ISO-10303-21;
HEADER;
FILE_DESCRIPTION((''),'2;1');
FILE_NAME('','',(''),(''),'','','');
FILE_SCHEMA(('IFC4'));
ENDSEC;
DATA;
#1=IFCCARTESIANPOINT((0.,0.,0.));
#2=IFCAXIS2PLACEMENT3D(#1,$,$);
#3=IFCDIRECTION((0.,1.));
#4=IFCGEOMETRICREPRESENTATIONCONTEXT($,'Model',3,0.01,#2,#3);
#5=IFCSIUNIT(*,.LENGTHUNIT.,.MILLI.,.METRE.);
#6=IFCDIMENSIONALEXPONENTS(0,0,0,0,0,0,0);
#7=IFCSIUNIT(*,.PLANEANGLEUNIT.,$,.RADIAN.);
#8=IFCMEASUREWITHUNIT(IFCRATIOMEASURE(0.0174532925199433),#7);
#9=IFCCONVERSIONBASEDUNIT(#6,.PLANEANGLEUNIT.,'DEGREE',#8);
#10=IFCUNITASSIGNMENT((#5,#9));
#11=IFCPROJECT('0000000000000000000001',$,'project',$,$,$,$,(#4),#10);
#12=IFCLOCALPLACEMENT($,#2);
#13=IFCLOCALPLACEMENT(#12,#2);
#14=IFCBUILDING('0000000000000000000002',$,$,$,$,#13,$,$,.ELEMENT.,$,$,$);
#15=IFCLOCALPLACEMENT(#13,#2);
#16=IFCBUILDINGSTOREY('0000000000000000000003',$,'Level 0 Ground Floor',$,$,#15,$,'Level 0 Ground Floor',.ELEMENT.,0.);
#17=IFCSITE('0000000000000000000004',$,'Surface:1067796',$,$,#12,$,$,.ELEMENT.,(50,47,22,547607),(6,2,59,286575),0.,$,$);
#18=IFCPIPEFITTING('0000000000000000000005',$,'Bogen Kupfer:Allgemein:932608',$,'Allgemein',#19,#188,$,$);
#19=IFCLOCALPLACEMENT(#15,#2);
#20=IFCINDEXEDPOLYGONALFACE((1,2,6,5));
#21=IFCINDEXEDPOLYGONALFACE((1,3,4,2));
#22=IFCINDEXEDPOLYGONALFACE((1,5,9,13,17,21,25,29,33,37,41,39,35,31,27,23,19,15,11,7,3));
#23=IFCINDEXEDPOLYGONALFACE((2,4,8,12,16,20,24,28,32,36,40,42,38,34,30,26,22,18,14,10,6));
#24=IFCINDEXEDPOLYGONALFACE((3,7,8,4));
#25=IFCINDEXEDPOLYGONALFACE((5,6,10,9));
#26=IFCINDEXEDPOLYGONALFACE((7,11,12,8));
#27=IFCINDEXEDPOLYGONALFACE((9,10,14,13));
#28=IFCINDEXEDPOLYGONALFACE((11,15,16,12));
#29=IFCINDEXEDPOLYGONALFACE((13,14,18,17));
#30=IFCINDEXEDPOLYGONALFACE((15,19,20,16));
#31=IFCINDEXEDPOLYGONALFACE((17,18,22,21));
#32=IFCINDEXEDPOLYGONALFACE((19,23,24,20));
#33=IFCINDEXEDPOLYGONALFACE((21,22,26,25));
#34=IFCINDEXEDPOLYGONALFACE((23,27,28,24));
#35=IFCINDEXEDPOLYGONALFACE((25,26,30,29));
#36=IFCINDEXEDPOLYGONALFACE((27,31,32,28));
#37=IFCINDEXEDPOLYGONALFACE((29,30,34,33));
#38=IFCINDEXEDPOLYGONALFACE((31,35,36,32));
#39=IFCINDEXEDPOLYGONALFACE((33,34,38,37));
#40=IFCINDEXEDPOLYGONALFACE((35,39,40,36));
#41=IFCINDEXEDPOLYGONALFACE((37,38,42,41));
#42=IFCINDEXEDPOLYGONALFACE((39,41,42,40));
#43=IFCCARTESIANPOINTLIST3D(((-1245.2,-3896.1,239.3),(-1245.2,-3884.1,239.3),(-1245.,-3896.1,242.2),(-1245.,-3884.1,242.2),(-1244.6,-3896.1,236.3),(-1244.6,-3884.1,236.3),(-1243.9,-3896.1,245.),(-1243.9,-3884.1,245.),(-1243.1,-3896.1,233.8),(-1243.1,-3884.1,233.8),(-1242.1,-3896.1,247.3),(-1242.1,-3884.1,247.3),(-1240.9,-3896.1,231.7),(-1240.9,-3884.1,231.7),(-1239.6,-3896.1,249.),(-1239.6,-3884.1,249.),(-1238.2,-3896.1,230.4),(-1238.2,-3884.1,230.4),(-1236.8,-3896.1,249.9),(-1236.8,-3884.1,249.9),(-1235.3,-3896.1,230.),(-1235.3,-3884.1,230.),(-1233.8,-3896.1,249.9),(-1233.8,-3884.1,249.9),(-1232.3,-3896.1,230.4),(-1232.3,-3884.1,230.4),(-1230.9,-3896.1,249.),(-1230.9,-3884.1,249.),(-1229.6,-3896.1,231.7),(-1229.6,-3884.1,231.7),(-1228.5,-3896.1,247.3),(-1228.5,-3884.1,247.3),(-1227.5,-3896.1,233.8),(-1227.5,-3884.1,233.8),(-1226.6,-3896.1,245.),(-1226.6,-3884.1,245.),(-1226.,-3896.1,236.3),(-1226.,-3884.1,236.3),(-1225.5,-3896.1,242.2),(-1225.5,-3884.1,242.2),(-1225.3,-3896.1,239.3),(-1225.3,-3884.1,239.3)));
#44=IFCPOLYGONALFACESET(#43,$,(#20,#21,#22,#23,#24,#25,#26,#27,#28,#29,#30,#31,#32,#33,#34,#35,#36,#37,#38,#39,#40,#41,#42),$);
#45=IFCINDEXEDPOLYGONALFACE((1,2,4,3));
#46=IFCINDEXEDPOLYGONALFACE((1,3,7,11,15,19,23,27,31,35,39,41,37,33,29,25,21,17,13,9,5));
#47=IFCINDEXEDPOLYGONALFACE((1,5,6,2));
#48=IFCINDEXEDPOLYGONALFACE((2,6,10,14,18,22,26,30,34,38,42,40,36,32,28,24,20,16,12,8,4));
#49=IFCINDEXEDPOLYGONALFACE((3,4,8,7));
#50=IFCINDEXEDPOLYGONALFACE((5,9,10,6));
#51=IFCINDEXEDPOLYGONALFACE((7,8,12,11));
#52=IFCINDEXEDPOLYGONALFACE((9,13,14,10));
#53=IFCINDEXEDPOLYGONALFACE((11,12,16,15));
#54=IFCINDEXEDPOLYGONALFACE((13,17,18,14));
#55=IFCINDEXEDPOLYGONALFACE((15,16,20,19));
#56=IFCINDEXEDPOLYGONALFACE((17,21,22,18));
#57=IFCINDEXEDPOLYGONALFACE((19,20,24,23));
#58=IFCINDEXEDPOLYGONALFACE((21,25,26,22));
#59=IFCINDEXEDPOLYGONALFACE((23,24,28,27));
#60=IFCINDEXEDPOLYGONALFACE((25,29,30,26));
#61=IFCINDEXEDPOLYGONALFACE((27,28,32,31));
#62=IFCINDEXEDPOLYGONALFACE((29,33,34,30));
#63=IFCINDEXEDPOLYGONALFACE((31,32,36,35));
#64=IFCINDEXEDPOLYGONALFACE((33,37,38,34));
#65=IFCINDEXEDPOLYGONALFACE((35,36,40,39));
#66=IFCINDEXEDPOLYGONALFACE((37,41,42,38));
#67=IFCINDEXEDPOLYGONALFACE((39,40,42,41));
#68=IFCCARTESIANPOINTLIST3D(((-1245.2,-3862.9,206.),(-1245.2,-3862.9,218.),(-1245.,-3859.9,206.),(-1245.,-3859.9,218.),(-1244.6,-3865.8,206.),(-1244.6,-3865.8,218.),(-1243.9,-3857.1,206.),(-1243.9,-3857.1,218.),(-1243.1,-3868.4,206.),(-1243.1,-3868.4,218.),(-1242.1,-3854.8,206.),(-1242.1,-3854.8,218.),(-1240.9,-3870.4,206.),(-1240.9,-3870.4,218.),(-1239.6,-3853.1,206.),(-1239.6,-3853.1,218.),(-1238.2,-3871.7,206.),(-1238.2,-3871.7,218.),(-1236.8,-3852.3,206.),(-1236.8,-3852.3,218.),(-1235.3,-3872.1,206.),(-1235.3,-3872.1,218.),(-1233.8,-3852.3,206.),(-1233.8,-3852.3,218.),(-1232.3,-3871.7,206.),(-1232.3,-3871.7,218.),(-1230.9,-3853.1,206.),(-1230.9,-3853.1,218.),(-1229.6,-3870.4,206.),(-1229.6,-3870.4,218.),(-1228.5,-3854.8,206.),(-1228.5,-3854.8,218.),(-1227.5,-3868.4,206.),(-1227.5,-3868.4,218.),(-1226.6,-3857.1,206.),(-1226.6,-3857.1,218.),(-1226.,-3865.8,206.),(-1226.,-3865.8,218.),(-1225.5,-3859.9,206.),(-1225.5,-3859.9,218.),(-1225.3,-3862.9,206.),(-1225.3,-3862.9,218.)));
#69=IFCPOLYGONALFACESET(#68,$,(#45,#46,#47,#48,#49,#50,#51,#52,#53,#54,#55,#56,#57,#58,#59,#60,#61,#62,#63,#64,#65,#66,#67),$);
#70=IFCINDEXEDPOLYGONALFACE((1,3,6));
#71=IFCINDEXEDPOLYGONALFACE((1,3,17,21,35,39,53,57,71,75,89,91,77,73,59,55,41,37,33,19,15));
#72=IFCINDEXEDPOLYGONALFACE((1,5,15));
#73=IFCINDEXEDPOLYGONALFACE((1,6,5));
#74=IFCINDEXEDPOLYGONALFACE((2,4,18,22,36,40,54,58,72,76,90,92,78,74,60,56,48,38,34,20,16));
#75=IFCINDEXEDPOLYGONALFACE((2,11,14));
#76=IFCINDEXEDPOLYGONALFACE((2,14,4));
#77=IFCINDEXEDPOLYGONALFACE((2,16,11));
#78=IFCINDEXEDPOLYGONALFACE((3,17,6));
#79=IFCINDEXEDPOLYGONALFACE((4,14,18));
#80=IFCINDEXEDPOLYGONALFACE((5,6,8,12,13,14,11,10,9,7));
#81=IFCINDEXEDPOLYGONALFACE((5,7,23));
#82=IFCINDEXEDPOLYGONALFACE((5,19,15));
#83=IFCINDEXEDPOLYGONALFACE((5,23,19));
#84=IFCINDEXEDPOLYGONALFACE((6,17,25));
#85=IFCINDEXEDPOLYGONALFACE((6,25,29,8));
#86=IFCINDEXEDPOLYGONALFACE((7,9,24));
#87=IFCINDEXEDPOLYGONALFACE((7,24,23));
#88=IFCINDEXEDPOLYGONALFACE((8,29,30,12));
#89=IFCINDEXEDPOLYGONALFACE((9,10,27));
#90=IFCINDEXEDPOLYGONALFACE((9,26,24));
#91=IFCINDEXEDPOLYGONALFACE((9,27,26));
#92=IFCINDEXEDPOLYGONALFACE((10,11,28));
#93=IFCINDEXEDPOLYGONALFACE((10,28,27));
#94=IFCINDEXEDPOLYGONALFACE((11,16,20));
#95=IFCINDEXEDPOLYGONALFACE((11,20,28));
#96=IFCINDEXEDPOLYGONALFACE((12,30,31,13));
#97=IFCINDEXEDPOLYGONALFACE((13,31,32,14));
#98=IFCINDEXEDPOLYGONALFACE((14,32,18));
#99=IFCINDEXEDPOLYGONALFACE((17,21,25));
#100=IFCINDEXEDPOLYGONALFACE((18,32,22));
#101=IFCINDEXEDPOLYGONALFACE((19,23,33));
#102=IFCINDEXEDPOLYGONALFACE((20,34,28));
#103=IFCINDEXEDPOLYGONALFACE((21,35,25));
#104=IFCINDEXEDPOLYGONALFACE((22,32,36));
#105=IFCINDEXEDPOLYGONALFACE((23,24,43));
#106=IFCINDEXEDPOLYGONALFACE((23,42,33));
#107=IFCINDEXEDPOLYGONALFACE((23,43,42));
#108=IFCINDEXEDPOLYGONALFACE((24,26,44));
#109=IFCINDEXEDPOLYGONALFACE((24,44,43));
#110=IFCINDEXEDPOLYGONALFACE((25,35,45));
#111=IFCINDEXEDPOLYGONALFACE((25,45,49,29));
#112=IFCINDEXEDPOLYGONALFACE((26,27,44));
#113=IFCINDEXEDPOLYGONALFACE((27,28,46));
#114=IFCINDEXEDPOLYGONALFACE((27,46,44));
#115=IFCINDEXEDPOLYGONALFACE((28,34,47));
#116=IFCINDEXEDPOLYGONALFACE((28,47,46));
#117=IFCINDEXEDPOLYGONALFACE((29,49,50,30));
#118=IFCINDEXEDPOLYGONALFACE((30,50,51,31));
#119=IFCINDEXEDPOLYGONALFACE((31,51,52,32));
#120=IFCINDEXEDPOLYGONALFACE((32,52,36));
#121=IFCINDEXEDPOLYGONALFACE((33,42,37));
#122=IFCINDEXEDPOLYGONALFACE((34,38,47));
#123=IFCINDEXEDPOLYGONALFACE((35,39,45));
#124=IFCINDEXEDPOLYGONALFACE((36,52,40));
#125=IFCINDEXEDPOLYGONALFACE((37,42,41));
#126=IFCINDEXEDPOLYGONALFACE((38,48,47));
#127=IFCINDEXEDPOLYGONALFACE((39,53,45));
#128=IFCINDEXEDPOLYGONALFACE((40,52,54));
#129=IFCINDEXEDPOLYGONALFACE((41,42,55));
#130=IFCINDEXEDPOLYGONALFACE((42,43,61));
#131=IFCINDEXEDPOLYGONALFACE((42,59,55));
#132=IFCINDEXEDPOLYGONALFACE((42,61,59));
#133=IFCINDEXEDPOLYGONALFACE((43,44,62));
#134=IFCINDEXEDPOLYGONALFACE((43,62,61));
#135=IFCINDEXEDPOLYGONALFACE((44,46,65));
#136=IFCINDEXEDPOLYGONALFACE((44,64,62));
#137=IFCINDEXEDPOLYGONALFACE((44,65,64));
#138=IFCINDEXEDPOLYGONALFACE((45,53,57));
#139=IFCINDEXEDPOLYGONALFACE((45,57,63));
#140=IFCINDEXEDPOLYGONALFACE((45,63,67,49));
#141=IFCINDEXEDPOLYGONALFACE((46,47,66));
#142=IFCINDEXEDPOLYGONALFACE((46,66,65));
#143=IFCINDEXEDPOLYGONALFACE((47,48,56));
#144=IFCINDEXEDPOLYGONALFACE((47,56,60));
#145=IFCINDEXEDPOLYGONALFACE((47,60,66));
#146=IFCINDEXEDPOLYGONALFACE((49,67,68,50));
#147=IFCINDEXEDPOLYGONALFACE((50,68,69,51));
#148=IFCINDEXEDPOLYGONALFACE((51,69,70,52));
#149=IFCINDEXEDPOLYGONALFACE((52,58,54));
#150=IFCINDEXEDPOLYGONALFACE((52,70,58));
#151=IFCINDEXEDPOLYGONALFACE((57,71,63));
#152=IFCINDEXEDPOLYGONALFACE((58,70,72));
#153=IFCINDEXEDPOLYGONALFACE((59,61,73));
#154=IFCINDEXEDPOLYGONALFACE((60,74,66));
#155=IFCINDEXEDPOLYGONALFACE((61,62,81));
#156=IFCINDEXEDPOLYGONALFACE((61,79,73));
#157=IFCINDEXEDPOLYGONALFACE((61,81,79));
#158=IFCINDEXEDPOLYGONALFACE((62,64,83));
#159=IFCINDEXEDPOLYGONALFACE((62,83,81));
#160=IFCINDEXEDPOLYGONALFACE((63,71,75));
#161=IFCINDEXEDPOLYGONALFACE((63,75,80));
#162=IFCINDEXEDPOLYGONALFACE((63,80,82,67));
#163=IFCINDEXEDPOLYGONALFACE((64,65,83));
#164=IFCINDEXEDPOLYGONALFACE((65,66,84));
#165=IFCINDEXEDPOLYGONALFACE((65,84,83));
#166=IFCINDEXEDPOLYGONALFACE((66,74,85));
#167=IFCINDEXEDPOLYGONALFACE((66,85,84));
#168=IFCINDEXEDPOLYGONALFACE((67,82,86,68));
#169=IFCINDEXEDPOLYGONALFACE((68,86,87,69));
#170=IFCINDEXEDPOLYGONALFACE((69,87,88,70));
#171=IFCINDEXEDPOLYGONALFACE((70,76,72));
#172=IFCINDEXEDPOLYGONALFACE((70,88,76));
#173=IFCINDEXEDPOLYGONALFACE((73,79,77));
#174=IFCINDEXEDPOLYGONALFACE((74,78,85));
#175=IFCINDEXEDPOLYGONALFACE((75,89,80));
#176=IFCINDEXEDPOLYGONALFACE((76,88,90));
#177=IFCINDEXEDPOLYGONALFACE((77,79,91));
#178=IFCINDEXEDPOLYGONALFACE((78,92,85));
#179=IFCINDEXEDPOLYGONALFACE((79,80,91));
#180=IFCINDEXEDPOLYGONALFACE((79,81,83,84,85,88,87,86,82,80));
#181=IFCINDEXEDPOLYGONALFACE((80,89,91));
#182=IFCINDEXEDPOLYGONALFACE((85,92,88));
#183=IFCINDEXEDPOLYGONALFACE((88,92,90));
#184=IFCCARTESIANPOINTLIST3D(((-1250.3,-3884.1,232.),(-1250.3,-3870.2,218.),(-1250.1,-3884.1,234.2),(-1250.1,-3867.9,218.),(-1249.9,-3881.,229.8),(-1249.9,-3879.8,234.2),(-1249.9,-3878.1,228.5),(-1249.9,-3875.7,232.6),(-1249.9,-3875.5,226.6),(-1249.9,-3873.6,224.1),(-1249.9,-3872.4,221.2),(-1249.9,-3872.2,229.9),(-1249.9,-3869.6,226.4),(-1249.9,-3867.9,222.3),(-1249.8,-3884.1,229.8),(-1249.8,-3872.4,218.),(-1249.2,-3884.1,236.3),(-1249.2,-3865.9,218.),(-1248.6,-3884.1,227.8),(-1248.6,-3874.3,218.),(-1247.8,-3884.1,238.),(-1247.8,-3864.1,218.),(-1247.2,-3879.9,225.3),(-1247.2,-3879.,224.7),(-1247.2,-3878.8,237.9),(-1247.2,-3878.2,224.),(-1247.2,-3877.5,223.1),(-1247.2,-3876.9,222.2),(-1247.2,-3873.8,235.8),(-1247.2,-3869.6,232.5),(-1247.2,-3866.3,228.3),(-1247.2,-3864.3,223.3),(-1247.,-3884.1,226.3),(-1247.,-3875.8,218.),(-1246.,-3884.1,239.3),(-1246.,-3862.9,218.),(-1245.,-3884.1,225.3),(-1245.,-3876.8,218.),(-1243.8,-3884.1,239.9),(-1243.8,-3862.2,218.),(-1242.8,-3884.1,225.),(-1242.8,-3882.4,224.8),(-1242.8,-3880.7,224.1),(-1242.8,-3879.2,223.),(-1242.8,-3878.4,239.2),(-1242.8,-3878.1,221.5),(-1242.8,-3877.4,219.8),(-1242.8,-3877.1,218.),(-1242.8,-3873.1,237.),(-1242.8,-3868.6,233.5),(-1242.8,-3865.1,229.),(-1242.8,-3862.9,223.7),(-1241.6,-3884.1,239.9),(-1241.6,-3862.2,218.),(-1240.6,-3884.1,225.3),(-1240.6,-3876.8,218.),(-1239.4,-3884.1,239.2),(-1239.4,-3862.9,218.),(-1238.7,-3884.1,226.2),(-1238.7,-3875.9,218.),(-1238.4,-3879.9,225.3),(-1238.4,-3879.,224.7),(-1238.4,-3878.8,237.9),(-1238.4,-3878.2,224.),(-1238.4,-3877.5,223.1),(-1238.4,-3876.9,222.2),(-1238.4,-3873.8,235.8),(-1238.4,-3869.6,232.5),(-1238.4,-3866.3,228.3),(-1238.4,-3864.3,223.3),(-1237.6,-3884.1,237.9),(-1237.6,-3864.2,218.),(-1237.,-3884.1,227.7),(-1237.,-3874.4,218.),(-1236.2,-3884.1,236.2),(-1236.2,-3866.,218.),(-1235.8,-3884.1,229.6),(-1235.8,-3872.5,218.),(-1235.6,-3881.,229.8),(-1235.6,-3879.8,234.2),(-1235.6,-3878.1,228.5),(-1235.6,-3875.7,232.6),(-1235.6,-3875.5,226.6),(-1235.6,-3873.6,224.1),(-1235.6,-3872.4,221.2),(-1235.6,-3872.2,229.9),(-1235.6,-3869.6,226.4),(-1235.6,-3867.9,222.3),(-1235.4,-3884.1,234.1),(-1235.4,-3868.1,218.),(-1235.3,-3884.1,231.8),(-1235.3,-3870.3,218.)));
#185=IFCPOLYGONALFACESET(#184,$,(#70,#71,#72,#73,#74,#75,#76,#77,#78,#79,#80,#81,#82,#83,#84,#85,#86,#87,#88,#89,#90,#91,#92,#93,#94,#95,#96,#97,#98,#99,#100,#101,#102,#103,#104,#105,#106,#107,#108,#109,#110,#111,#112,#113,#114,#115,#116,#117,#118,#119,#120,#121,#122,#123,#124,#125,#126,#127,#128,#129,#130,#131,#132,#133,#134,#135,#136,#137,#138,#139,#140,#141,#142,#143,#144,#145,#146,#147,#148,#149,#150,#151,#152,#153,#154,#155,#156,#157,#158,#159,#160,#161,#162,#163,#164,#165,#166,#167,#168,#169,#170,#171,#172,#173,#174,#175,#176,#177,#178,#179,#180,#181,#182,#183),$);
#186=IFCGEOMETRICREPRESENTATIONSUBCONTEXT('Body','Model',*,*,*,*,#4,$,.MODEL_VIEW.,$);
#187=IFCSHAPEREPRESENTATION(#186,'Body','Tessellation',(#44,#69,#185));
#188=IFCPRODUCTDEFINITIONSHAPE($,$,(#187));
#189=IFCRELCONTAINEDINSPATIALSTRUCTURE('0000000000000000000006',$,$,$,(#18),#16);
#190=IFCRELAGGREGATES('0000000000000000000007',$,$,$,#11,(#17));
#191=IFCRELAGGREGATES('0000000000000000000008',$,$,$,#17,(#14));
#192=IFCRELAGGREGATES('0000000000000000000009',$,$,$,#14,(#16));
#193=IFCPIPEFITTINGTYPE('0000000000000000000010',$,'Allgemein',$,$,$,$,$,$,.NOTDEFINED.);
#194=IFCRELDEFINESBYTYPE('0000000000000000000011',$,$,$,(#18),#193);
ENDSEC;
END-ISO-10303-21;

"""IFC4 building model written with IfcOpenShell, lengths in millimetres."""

from ifc_helpers import new_model, entity, si_unit, converted_unit, direction, frame, frame_2d, origin, place, context, subcontext, project, spatial, circle, extrude, source, transform, mapped, type_object, type_shapes, element, save


model = new_model("IFC4")

# Units and contexts
model_context = context("Model", 3, precision=0.01, world=origin(), true_north=direction((0.0, 1.0)))
body_context = subcontext(model_context, "Body", "Model", "MODEL_VIEW")
ifc_project = project(units=[si_unit("LENGTHUNIT", "METRE", prefix="MILLI"), converted_unit("PLANEANGLEUNIT", "DEGREE", entity("IfcRatioMeasure", 0.0174532925199433), si_unit("PLANEANGLEUNIT", "RADIAN"), dimensions=[0, 0, 0, 0, 0, 0, 0])], contexts=[model_context])

# Site, building, storey
site_placement = place(None, origin())
site = spatial("IfcSite", under=ifc_project, at=site_placement, Name="Surface:1067796", CompositionType="ELEMENT", RefLatitude=(50, 47, 22, 547607), RefLongitude=(6, 2, 59, 286575), RefElevation=0.0)
building_placement = place(site_placement, origin())
building = spatial("IfcBuilding", under=site, at=building_placement, CompositionType="ELEMENT")
storey_placement = place(building_placement, origin())
storey = spatial("IfcBuildingStorey", under=building, at=storey_placement, Name="Level 0 Ground Floor", LongName="Level 0 Ground Floor", CompositionType="ELEMENT", Elevation=0.0)

# Pipe fitting
pipe_fitting_type_1 = type_object("IfcPipeFittingType", Name="Allgemein", PredefinedType="NOTDEFINED")
ifc_direction = entity("IfcDirection", [0.0, 0.0, -1.0])
trimmed_curve = entity("IfcTrimmedCurve", entity("IfcCircle", entity("IfcAxis2Placement2D", entity("IfcCartesianPoint", [-14.5, 0.0]), entity("IfcDirection", [0.0, 1.0])), 14.5), [entity("IfcParameterValue", 270.0)], [entity("IfcParameterValue", 0.0)], True, "PARAMETER")
shared_shape_1 = source(origin(), body_context, "Body", "SolidModel", [
    extrude(circle(Radius=10.0, at=frame_2d((0.0, 0.0), x_axis=(1.0, 0.0))), frame((0.0, 22.0, 0.0), z_axis=(0.0, 1.0, 0.0), x_axis=(-1.0, 0.0, 0.0)), (0.0, 0.0, 1.0), 12.0),
    extrude(circle(Radius=10.0, at=frame_2d((0.0, 0.0), x_axis=(1.0, 0.0))), frame((-34.0, 0.0, 0.0), z_axis=(1.0, 0.0, 0.0), x_axis=(0.0, 1.0, 0.0)), (0.0, 0.0, 1.0), 12.0),
    entity("IfcSurfaceCurveSweptAreaSolid", entity("IfcCircleProfileDef", "AREA", None, entity("IfcAxis2Placement2D", entity("IfcCartesianPoint", [0.0, 7.5]), entity("IfcDirection", [1.0, 0.0])), 7.5), entity("IfcAxis2Placement3D", entity("IfcCartesianPoint", [-7.5, 22.0, 0.0]), ifc_direction, entity("IfcDirection", [1.0, 0.0, 0.0])), trimmed_curve, 0.0, 90.0, entity("IfcSurfaceOfLinearExtrusion", entity("IfcArbitraryOpenProfileDef", "CURVE", None, trimmed_curve), entity("IfcAxis2Placement3D", entity("IfcCartesianPoint", [0.0, 0.0, -304.8])), ifc_direction, 1.0)),
])
type_shapes(pipe_fitting_type_1, [shared_shape_1])
for number, where, z_axis, x_axis, name in (
    (1, (-1235.3, -3862.1, 240.0), (1.0, 0.0, 0.0), (0.0, 0.0, 1.0), "Bogen Kupfer:Allgemein:932608"),
):
    element("IfcPipeFitting", number, at=place(storey_placement, frame(where, z_axis=z_axis, x_axis=x_axis)), inside=storey, type_object=pipe_fitting_type_1, Name=name, ObjectType="Allgemein", context=body_context, shape_type="MappedRepresentation", body=[
        mapped(shared_shape_1, transform((0.0, 0.0, 0.0), scale=1.0)),
    ])

save(model, "model.ifc")
